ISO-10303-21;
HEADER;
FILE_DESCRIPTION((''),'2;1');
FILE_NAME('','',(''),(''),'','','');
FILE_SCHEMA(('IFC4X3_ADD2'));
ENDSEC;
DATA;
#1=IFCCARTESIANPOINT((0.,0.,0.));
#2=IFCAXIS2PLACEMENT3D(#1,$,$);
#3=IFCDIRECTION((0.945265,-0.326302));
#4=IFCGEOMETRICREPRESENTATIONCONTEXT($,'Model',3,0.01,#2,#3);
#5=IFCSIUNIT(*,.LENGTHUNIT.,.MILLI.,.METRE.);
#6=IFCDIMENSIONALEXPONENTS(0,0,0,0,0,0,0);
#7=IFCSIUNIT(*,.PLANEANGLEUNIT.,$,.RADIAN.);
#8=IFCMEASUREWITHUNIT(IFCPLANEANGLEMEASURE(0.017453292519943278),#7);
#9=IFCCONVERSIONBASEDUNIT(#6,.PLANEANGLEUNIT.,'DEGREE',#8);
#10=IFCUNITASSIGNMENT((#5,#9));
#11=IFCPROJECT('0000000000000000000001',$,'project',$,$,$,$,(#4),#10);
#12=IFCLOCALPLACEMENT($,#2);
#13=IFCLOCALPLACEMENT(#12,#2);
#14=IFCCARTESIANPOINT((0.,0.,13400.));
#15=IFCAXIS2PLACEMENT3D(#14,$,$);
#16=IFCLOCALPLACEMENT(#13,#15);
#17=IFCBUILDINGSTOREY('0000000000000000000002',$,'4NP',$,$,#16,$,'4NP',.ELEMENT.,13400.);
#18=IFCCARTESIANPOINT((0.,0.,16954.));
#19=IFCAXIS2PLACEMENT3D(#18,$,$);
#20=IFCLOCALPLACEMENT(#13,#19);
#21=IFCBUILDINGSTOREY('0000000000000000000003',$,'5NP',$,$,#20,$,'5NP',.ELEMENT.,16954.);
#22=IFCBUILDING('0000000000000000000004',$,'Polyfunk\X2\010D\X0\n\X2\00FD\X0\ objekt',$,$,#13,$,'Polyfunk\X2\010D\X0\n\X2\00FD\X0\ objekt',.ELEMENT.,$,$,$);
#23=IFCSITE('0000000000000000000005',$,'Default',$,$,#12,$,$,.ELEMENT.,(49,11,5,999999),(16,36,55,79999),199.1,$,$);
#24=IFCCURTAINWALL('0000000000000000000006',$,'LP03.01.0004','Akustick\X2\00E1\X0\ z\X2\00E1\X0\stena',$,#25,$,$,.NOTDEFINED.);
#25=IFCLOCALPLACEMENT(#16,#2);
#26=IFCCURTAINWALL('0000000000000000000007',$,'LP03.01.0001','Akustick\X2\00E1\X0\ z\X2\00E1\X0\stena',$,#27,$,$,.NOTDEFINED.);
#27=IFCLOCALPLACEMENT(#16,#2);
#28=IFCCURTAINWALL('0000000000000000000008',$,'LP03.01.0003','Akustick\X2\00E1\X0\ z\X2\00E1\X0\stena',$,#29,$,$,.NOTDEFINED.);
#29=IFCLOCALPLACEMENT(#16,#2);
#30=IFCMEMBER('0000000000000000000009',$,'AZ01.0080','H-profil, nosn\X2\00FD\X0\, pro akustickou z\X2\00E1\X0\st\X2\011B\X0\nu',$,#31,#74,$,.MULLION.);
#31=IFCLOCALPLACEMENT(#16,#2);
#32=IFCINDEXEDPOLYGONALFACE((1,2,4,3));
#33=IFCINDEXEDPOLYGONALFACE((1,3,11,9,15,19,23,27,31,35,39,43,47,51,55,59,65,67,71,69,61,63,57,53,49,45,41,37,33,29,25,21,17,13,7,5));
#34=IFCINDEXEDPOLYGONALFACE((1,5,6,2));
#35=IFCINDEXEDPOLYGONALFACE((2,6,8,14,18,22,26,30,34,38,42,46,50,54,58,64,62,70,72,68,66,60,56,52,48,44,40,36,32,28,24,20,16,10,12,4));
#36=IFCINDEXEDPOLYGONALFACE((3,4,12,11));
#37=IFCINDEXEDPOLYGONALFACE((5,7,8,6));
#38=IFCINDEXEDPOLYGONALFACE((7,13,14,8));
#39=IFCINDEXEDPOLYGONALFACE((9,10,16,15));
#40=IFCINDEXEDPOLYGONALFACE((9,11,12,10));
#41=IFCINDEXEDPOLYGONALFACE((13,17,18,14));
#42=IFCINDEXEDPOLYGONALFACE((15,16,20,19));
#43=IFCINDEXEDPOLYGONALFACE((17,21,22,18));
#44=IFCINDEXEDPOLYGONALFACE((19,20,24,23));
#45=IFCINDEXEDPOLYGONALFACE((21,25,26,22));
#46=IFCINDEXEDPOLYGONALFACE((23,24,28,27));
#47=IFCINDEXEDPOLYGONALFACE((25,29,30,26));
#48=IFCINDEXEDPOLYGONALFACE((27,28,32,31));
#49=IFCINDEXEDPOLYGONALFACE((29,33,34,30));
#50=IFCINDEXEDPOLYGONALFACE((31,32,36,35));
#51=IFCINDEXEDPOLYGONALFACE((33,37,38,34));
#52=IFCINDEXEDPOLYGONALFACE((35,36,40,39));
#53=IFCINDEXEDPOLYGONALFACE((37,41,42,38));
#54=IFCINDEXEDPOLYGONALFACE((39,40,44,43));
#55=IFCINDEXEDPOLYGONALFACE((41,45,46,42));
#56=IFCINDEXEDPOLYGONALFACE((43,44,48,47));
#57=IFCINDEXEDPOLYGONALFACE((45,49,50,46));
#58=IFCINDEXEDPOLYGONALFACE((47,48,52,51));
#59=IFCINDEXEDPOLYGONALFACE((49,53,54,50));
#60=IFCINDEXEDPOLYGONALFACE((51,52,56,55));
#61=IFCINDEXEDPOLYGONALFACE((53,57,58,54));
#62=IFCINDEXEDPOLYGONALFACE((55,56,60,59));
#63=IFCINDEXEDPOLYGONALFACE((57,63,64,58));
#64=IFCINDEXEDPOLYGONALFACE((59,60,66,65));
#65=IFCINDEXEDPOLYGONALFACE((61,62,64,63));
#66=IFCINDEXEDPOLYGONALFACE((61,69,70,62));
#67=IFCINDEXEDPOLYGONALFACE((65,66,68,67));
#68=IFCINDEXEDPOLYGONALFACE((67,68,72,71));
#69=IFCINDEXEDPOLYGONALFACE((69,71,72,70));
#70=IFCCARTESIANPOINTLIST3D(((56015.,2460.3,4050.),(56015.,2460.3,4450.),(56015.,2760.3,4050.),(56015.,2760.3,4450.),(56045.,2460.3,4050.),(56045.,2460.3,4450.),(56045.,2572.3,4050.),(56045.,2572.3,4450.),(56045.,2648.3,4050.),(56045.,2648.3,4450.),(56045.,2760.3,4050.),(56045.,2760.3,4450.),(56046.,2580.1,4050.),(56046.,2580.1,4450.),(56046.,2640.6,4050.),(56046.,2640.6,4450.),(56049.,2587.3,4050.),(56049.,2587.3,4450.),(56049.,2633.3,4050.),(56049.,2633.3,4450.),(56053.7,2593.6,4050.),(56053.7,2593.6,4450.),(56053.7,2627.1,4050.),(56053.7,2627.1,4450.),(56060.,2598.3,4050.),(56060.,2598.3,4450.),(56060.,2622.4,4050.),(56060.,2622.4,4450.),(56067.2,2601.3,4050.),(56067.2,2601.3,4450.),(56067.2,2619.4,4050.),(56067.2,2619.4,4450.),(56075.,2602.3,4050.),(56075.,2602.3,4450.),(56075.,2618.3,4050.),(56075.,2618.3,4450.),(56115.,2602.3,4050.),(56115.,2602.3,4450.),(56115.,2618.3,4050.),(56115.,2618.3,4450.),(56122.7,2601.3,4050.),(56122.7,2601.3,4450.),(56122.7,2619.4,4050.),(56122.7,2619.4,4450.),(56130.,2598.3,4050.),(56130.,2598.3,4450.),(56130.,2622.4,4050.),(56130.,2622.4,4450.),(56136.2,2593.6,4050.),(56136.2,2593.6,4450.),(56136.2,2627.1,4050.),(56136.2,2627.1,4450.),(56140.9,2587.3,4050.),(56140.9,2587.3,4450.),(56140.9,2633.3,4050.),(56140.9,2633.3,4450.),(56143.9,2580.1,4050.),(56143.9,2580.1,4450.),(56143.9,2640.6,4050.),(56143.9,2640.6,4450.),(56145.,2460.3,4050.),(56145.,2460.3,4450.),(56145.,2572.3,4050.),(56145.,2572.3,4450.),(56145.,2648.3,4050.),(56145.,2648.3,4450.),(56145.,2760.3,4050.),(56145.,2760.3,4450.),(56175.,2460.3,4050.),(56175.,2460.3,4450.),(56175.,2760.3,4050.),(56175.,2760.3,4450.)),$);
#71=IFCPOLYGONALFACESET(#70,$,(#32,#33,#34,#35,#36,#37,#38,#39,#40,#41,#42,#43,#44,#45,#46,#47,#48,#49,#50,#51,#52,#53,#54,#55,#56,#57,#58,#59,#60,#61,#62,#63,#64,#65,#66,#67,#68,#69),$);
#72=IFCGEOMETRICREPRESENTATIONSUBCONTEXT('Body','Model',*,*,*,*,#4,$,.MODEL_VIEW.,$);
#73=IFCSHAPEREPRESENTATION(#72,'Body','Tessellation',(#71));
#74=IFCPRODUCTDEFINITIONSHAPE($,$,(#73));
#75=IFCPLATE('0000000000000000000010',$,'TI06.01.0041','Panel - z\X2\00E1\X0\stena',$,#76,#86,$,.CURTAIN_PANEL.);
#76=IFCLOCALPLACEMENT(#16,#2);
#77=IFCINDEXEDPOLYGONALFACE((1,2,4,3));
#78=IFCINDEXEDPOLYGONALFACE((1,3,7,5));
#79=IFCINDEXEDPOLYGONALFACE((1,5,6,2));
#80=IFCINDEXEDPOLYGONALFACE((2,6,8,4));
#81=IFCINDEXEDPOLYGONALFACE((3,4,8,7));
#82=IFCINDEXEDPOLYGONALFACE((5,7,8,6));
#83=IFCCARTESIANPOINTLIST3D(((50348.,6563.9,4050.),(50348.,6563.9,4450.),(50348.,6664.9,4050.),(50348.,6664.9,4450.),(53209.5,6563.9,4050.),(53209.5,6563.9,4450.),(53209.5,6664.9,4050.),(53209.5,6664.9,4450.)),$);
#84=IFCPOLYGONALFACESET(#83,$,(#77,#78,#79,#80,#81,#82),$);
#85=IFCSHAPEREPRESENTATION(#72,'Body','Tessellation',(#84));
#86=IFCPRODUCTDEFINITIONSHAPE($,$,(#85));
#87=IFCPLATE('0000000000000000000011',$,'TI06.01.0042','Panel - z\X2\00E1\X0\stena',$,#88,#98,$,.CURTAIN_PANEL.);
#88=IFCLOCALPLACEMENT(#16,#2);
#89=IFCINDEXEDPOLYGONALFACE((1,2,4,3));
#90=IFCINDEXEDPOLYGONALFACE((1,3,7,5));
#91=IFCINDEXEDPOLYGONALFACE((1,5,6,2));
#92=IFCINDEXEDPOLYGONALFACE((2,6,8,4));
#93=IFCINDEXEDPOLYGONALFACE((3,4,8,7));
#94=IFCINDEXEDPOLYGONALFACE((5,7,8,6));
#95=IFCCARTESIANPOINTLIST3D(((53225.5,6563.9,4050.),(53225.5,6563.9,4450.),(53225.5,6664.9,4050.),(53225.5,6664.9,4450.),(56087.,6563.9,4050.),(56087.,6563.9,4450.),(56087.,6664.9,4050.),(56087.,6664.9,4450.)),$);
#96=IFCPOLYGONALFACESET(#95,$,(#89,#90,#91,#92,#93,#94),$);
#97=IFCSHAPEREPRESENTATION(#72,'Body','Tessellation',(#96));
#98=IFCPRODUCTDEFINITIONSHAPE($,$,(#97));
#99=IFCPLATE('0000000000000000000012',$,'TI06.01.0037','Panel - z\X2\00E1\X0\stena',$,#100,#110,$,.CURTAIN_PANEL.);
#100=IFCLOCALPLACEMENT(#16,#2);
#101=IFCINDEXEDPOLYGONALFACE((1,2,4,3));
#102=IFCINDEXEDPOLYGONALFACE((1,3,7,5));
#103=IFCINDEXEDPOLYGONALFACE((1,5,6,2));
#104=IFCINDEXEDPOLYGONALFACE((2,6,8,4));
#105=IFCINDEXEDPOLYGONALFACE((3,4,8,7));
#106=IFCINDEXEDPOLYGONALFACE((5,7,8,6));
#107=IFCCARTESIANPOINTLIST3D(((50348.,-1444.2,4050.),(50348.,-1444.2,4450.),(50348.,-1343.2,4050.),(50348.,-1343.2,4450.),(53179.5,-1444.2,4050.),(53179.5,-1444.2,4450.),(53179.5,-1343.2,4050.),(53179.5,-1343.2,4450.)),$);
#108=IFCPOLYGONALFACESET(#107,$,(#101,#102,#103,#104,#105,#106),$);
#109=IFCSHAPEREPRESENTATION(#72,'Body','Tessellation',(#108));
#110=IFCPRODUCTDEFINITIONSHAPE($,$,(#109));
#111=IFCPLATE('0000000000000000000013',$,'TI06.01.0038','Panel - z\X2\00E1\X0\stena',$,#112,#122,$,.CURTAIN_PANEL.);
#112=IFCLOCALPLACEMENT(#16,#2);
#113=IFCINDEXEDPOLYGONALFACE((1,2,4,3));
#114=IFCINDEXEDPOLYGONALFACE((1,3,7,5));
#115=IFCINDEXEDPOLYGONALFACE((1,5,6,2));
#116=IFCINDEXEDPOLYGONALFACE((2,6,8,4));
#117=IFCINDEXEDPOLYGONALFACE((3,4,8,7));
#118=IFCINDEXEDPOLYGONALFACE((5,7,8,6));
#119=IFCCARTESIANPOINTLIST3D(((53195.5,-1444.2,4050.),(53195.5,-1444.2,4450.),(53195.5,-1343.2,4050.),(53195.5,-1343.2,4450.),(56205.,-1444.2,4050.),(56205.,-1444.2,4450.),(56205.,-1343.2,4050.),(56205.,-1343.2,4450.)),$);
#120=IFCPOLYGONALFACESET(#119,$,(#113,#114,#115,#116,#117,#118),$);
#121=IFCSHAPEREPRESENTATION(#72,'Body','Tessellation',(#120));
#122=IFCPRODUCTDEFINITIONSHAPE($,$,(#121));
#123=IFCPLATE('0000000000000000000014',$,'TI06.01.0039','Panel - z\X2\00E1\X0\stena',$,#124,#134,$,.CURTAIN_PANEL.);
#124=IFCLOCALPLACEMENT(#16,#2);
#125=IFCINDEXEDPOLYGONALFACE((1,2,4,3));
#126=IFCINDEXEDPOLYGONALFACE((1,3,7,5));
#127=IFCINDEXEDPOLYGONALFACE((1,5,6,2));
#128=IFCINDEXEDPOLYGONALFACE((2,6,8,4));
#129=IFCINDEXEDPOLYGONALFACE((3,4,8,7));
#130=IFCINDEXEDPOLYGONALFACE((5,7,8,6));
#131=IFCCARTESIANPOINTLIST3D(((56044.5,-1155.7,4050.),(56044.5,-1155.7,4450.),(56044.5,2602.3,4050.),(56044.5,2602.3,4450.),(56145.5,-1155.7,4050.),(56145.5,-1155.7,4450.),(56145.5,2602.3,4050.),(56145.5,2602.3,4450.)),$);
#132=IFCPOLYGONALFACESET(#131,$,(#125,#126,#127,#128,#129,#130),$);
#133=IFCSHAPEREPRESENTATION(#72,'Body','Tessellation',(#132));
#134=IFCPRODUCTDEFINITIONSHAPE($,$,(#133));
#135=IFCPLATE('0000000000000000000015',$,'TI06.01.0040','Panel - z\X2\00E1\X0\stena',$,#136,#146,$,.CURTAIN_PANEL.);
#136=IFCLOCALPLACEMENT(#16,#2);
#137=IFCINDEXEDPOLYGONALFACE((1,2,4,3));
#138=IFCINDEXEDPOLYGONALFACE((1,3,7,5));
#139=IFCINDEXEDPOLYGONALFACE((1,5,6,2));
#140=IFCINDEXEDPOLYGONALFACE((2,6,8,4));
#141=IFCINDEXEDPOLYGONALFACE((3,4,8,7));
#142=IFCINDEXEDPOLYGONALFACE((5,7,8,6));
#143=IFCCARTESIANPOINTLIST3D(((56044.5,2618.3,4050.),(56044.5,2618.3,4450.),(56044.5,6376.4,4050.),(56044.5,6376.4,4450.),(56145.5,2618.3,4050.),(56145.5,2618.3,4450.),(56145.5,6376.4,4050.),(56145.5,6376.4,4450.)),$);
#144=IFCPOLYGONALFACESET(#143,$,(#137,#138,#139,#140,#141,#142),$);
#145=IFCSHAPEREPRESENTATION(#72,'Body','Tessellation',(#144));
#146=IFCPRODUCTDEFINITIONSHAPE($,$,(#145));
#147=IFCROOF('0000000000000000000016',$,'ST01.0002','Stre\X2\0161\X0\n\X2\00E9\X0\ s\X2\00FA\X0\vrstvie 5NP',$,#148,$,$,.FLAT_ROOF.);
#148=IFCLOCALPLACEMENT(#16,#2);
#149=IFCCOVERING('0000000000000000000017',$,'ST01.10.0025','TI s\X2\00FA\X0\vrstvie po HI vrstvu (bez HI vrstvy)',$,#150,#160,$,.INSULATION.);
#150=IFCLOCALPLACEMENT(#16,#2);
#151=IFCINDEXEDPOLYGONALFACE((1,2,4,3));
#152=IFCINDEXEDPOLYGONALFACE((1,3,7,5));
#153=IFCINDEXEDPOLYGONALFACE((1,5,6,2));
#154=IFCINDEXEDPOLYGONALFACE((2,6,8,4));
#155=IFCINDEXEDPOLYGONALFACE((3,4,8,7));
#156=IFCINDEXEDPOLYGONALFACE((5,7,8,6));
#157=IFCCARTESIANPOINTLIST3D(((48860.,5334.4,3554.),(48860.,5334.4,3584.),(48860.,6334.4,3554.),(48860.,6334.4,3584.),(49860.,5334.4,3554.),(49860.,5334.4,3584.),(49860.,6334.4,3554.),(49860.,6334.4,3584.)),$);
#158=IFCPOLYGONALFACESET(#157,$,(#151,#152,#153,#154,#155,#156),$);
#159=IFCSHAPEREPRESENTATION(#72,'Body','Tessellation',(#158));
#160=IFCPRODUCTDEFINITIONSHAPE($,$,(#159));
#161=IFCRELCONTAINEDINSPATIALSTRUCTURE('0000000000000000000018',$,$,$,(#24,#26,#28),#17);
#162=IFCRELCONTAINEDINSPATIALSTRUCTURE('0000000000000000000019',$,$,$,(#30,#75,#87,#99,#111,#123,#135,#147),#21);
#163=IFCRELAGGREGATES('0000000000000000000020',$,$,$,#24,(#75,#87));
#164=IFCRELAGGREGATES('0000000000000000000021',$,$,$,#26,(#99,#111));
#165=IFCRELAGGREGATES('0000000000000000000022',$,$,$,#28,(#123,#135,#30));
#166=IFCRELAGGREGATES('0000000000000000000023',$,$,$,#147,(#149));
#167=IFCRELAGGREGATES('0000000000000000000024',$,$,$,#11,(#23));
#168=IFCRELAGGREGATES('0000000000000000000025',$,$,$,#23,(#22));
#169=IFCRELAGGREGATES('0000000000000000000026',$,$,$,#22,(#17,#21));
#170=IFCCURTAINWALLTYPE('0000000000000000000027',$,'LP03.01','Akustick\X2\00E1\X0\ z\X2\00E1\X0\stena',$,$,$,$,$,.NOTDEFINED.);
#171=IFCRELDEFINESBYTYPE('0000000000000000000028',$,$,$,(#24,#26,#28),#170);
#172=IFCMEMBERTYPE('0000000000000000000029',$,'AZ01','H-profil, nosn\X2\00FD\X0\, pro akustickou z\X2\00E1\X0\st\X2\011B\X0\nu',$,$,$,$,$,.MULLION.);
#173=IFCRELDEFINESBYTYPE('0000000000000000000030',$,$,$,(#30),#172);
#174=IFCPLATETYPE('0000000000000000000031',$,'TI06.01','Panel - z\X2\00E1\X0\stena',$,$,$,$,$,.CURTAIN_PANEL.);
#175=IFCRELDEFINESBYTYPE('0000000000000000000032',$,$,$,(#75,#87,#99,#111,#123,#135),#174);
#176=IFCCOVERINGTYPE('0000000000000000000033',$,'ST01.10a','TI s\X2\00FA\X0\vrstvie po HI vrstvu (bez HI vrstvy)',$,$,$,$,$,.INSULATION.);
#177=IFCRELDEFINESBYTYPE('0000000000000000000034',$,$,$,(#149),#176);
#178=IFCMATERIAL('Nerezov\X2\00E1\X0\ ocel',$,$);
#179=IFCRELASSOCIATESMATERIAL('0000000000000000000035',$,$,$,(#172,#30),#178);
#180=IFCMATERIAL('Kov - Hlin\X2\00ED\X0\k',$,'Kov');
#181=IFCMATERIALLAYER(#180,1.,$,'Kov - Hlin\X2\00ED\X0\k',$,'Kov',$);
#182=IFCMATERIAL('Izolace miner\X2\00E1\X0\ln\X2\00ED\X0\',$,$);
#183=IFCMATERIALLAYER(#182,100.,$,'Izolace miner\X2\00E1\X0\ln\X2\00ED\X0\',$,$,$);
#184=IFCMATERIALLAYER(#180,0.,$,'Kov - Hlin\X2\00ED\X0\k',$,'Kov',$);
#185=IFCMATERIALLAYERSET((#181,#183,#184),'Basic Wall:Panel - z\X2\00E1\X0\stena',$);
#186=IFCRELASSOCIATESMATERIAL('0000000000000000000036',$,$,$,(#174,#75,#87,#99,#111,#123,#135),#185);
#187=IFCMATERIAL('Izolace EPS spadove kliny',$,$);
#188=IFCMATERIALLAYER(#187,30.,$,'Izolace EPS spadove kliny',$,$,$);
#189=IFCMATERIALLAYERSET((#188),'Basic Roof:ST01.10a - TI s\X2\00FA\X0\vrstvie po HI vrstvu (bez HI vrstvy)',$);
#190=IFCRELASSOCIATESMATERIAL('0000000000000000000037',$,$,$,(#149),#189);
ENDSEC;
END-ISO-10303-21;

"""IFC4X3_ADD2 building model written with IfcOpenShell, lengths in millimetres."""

from ifc_helpers import new_model, entity, si_unit, converted_unit, direction, frame, frame_2d, origin, origin_2d_with_axis, place, context, subcontext, project, spatial, polyline, circle_curve, parameter, trimmed, segment, composite_curve, rectangle, outline, extrude, source, transform, mapped, material, layer, layer_set, layer_usage, material_profile, profile_set, profile_usage, type_object, element, aggregate, save


model = new_model("IFC4X3_ADD2")

# Units and contexts
model_context = context("Model", 3, precision=0.01, world=origin(), true_north=direction((0.945265, -0.326302)))
body_context = subcontext(model_context, "Body", "Model", "MODEL_VIEW")
ifc_project = project(units=[si_unit("LENGTHUNIT", "METRE", prefix="MILLI"), converted_unit("PLANEANGLEUNIT", "DEGREE", entity("IfcPlaneAngleMeasure", 0.017453292519943278), si_unit("PLANEANGLEUNIT", "RADIAN"), dimensions=[0, 0, 0, 0, 0, 0, 0])], contexts=[model_context])

# Site, building, storey
site_placement = place(None, origin())
site = spatial("IfcSite", under=ifc_project, at=site_placement, Name="Default", CompositionType="ELEMENT", RefLatitude=(49, 11, 5, 999999), RefLongitude=(16, 36, 55, 79999), RefElevation=199.1)
building_placement = place(site_placement, origin())
building = spatial("IfcBuilding", under=site, at=building_placement, Name="Polyfunkčný objekt", LongName="Polyfunkčný objekt", CompositionType="ELEMENT")
storey_1_placement = place(building_placement, frame((0.0, 0.0, 13400.0)))
storey_1 = spatial("IfcBuildingStorey", under=building, at=storey_1_placement, Name="4NP", LongName="4NP", CompositionType="ELEMENT", Elevation=13400.0)

# Curtain wall
curtain_wall_type = type_object("IfcCurtainWallType", Name="LP03.01", Description="Akustická zástena", PredefinedType="NOTDEFINED")
curtain_wall_1_placement = place(storey_1_placement, frame((0.0, 0.0, -13400.0)))
curtain_wall_1 = element("IfcCurtainWall", 1, at=curtain_wall_1_placement, inside=storey_1, type_object=curtain_wall_type, Name="LP03.01.0004", Description="Akustická zástena", PredefinedType="NOTDEFINED")

# Shared definitions
storey_2_placement = place(building_placement, frame((0.0, 0.0, 16954.0)))
storey_2 = spatial("IfcBuildingStorey", under=building, at=storey_2_placement, Name="5NP", LongName="5NP", CompositionType="ELEMENT", Elevation=16954.0)

# Shared definitions
ifc_material_1 = material(Name="Nerezová ocel")
ifc_material_profile = material_profile(ifc_material_1, outline(composite_curve([segment(polyline([(50.0, -150.0), (80.0, -150.0)]), True, "CONTINUOUS"), segment(polyline([(80.0, -150.0), (80.0, 150.0)]), True, "CONTINUOUS"), segment(polyline([(80.0, 150.0), (50.0, 150.0)]), True, "CONTINUOUS"), segment(polyline([(50.0, 150.0), (50.0, 38.0)]), True, "CONTINUOUS"), segment(trimmed(circle_curve(frame_2d((20.0, 38.0), x_axis=(0.0, 1.0)), 30.0), [parameter(180.0)], [parameter(270.0)], True, "PARAMETER"), False, "CONTINUOUS"), segment(polyline([(20.0, 8.0), (-20.0, 8.0)]), True, "CONTINUOUS"), segment(trimmed(circle_curve(frame_2d((-20.0, 38.0), x_axis=(0.0, 1.0)), 30.0), [parameter(90.0)], [parameter(180.0)], True, "PARAMETER"), False, "CONTINUOUS"), segment(polyline([(-50.0, 38.0), (-50.0, 150.0)]), True, "CONTINUOUS"), segment(polyline([(-50.0, 150.0), (-80.0, 150.0)]), True, "CONTINUOUS"), segment(polyline([(-80.0, 150.0), (-80.0, -150.0)]), True, "CONTINUOUS"), segment(polyline([(-80.0, -150.0), (-50.0, -150.0)]), True, "CONTINUOUS"), segment(polyline([(-50.0, -150.0), (-50.0, -38.0)]), True, "CONTINUOUS"), segment(trimmed(circle_curve(frame_2d((-20.0, -38.0), x_axis=(0.0, 1.0)), 30.0), [parameter(0.0)], [parameter(90.0)], True, "PARAMETER"), False, "CONTINUOUS"), segment(polyline([(-20.0, -8.0), (20.0, -8.0)]), True, "CONTINUOUS"), segment(trimmed(circle_curve(frame_2d((20.0, -38.0), x_axis=(0.0, 1.0)), 30.0), [parameter(270.0)], [parameter(0.0)], True, "PARAMETER"), False, "CONTINUOUS"), segment(polyline([(50.0, -38.0), (50.0, -150.0)]), True, "CONTINUOUS")], self_intersect=False)), Name="Profil zástena")
ifc_profile_set = profile_set([ifc_material_profile], Name="Profil zástena")
ifc_profile_usage = profile_usage(ifc_profile_set)
member_type = type_object("IfcMemberType", Name="AZ01", Description="H-profil, nosný, pro akustickou zástěnu", PredefinedType="MULLION", material=ifc_profile_set)

# Curtain wall
curtain_wall_2_placement = place(storey_1_placement, frame((0.0, 0.0, -13400.0)))
curtain_wall_2 = element("IfcCurtainWall", 2, at=curtain_wall_2_placement, inside=storey_1, type_object=curtain_wall_type, Name="LP03.01.0001", Description="Akustická zástena", PredefinedType="NOTDEFINED")

# Curtain wall, member
curtain_wall_3_placement = place(storey_1_placement, frame((0.0, 0.0, -13400.0)))
curtain_wall_3 = element("IfcCurtainWall", 3, at=curtain_wall_3_placement, inside=storey_1, type_object=curtain_wall_type, Name="LP03.01.0003", Description="Akustická zástena", PredefinedType="NOTDEFINED")
shared_shape_1 = source(origin(), body_context, "Body", "SweptSolid", [
    extrude(outline(composite_curve([segment(polyline([(-150.0, -50.0), (-150.0, -80.0)]), True, "CONTINUOUS"), segment(polyline([(-150.0, -80.0), (150.0, -80.0)]), True, "CONTINUOUS"), segment(polyline([(150.0, -80.0), (150.0, -50.0)]), True, "CONTINUOUS"), segment(polyline([(150.0, -50.0), (38.0, -50.0)]), True, "CONTINUOUS"), segment(trimmed(circle_curve(frame_2d((38.0, -20.0), x_axis=(1.0, 0.0)), 30.0), [parameter(180.0)], [parameter(270.0)], True, "PARAMETER"), False, "CONTINUOUS"), segment(polyline([(8.0, -20.0), (8.0, 20.0)]), True, "CONTINUOUS"), segment(trimmed(circle_curve(frame_2d((38.0, 20.0), x_axis=(1.0, 0.0)), 30.0), [parameter(90.0)], [parameter(180.0)], True, "PARAMETER"), False, "CONTINUOUS"), segment(polyline([(38.0, 50.0), (150.0, 50.0)]), True, "CONTINUOUS"), segment(polyline([(150.0, 50.0), (150.0, 80.0)]), True, "CONTINUOUS"), segment(polyline([(150.0, 80.0), (-150.0, 80.0)]), True, "CONTINUOUS"), segment(polyline([(-150.0, 80.0), (-150.0, 50.0)]), True, "CONTINUOUS"), segment(polyline([(-150.0, 50.0), (-38.0, 50.0)]), True, "CONTINUOUS"), segment(trimmed(circle_curve(frame_2d((-38.0, 20.0), x_axis=(1.0, 0.0)), 30.0), [parameter(0.0)], [parameter(90.0)], True, "PARAMETER"), False, "CONTINUOUS"), segment(polyline([(-8.0, 20.0), (-8.0, -20.0)]), True, "CONTINUOUS"), segment(trimmed(circle_curve(frame_2d((-38.0, -20.0), x_axis=(1.0, 0.0)), 30.0), [parameter(270.0)], [parameter(360.0)], True, "PARAMETER"), False, "CONTINUOUS"), segment(polyline([(-38.0, -50.0), (-150.0, -50.0)]), True, "CONTINUOUS")], self_intersect=False)), frame((0.0, 0.0, -400.0), z_axis=(0.0, 0.0, -1.0), x_axis=(1.0, 0.0, 0.0)), (0.0, 0.0, -1.0), 400.0),
])
member_1_placement = place(curtain_wall_3_placement, frame((56095.0, 2610.3, 17450.0), z_axis=(0.0, 0.0, -1.0), x_axis=(0.0, 1.0, 0.0)))
member_1 = element("IfcMember", 4, at=member_1_placement, inside=storey_2, type_object=member_type, material=ifc_profile_usage, Name="AZ01.0080", Description="H-profil, nosný, pro akustickou zástěnu", PredefinedType="MULLION", context=body_context, shape_type="MappedRepresentation", body=[
    mapped(shared_shape_1, transform((0.0, 0.0, 0.0), scale=1.0)),
])

# Plates
ifc_material_2 = material(Name="Kov - Hliník", Category="Kov")
ifc_layer_1 = layer(ifc_material_2, 1.0, Name="Kov - Hliník", Category="Kov")
ifc_material_3 = material(Name="Izolace minerální")
ifc_layer_2 = layer(ifc_material_3, 100.0, Name="Izolace minerální")
ifc_layer_3 = layer(ifc_material_2, 0.0, Name="Kov - Hliník", Category="Kov")
ifc_layer_set_1 = layer_set([ifc_layer_1, ifc_layer_2, ifc_layer_3], Name="Basic Wall:Panel - zástena")
ifc_layer_usage_1 = layer_usage(ifc_layer_set_1, "AXIS2", "POSITIVE", -50.5)
plate_type = type_object("IfcPlateType", Name="TI06.01", Description="Panel - zástena", PredefinedType="CURTAIN_PANEL", material=ifc_layer_set_1)
plate_1_placement = place(storey_1_placement, frame((50348.0, 6614.4, 4050.0)))
plate_1 = element("IfcPlate", 5, at=plate_1_placement, inside=storey_2, type_object=plate_type, material=ifc_layer_usage_1, Name="TI06.01.0041", Description="Panel - zástena", PredefinedType="CURTAIN_PANEL", context=body_context, shape_type="SweptSolid", body=[
    extrude(rectangle(XDim=101.0, YDim=2861.5, at=origin_2d_with_axis()), frame((1430.7, 0.0, 0.0), z_axis=(0.0, 0.0, 1.0), x_axis=(0.0, 1.0, 0.0)), (0.0, 0.0, 1.0), 400.0),
])
ifc_layer_usage_2 = layer_usage(ifc_layer_set_1, "AXIS2", "POSITIVE", -50.5)
plate_2_placement = place(storey_1_placement, frame((53225.5, 6614.4, 4050.0)))
plate_2 = element("IfcPlate", 6, at=plate_2_placement, inside=storey_2, type_object=plate_type, material=ifc_layer_usage_2, Name="TI06.01.0042", Description="Panel - zástena", PredefinedType="CURTAIN_PANEL", context=body_context, shape_type="SweptSolid", body=[
    extrude(rectangle(XDim=101.0, YDim=2861.5, at=origin_2d_with_axis()), frame((1430.8, 0.0, 0.0), z_axis=(0.0, 0.0, 1.0), x_axis=(0.0, 1.0, 0.0)), (0.0, 0.0, 1.0), 400.0),
])
aggregate(curtain_wall_1, [plate_1, plate_2])
ifc_layer_usage_3 = layer_usage(ifc_layer_set_1, "AXIS2", "POSITIVE", -50.5)
plate_3_placement = place(storey_1_placement, frame((50348.0, -1393.7, 4050.0)))
plate_3 = element("IfcPlate", 7, at=plate_3_placement, inside=storey_2, type_object=plate_type, material=ifc_layer_usage_3, Name="TI06.01.0037", Description="Panel - zástena", PredefinedType="CURTAIN_PANEL", context=body_context, shape_type="SweptSolid", body=[
    extrude(rectangle(XDim=101.0, YDim=2831.5, at=frame_2d((0.0, 0.0), x_axis=(1.0, 0.0))), frame((1415.8, 0.0, 0.0), z_axis=(0.0, 0.0, 1.0), x_axis=(0.0, 1.0, 0.0)), (0.0, 0.0, 1.0), 400.0),
])
ifc_layer_usage_4 = layer_usage(ifc_layer_set_1, "AXIS2", "POSITIVE", -50.5)
plate_4_placement = place(storey_1_placement, frame((53195.5, -1393.7, 4050.0)))
plate_4 = element("IfcPlate", 8, at=plate_4_placement, inside=storey_2, type_object=plate_type, material=ifc_layer_usage_4, Name="TI06.01.0038", Description="Panel - zástena", PredefinedType="CURTAIN_PANEL", context=body_context, shape_type="SweptSolid", body=[
    extrude(rectangle(XDim=101.0, YDim=3009.5, at=frame_2d((0.0, 0.0), x_axis=(1.0, 0.0))), frame((1504.7, 0.0, 0.0), z_axis=(0.0, 0.0, 1.0), x_axis=(0.0, 1.0, 0.0)), (0.0, 0.0, 1.0), 400.0),
])
aggregate(curtain_wall_2, [plate_3, plate_4])
ifc_layer_usage_5 = layer_usage(ifc_layer_set_1, "AXIS2", "NEGATIVE", 50.5)
plate_5_placement = place(storey_1_placement, frame((56095.0, -1155.7, 4050.0), z_axis=(0.0, 0.0, 1.0), x_axis=(0.0, 1.0, 0.0)))
plate_5 = element("IfcPlate", 9, at=plate_5_placement, inside=storey_2, type_object=plate_type, material=ifc_layer_usage_5, Name="TI06.01.0039", Description="Panel - zástena", PredefinedType="CURTAIN_PANEL", context=body_context, shape_type="SweptSolid", body=[
    extrude(rectangle(XDim=101.0, YDim=3758.1, at=frame_2d((0.0, 0.0), x_axis=(1.0, 0.0))), frame((1879.0, 0.0, 0.0), z_axis=(0.0, 0.0, 1.0), x_axis=(0.0, 1.0, 0.0)), (0.0, 0.0, 1.0), 400.0),
])
ifc_layer_usage_6 = layer_usage(ifc_layer_set_1, "AXIS2", "NEGATIVE", 50.5)
plate_6_placement = place(storey_1_placement, frame((56095.0, 2618.3, 4050.0), z_axis=(0.0, 0.0, 1.0), x_axis=(0.0, 1.0, 0.0)))
plate_6 = element("IfcPlate", 10, at=plate_6_placement, inside=storey_2, type_object=plate_type, material=ifc_layer_usage_6, Name="TI06.01.0040", Description="Panel - zástena", PredefinedType="CURTAIN_PANEL", context=body_context, shape_type="SweptSolid", body=[
    extrude(rectangle(XDim=101.0, YDim=3758.1, at=frame_2d((0.0, 0.0), x_axis=(1.0, 0.0))), frame((1879.0, 0.0, 0.0), z_axis=(0.0, 0.0, 1.0), x_axis=(0.0, 1.0, 0.0)), (0.0, 0.0, 1.0), 400.0),
])
aggregate(curtain_wall_3, [plate_5, plate_6, member_1])

# Roof, covering
roof = element("IfcRoof", 11, inside=storey_2, Name="ST01.0002", Description="Strešné súvrstvie 5NP", PredefinedType="FLAT_ROOF")
ifc_material_4 = material(Name="Izolace EPS spadove kliny")
ifc_layer_4 = layer(ifc_material_4, 30.0, Name="Izolace EPS spadove kliny")
ifc_layer_set_2 = layer_set([ifc_layer_4], Name="Basic Roof:ST01.10a - TI súvrstvie po HI vrstvu (bez HI vrstvy)")
covering_type_1 = type_object("IfcCoveringType", Name="ST01.10a", Description="TI súvrstvie po HI vrstvu (bez HI vrstvy)", PredefinedType="INSULATION")
placement_1 = place(storey_2_placement, frame((48860.0, 5334.4, 0.0)))
covering_1_placement = place(placement_1, origin())
covering_1 = element("IfcCovering", 12, at=covering_1_placement, type_object=covering_type_1, material=ifc_layer_set_2, Name="ST01.10.0025", Description="TI súvrstvie po HI vrstvu (bez HI vrstvy)", PredefinedType="INSULATION", context=body_context, shape_type="SweptSolid", body=[
    extrude(rectangle(XDim=1000.0, YDim=1000.0, at=origin_2d_with_axis()), frame((500.0, 500.0, 0.0)), (0.0, 0.0, 1.0), 30.0),
])
aggregate(roof, [covering_1])

save(model, "model.ifc")
